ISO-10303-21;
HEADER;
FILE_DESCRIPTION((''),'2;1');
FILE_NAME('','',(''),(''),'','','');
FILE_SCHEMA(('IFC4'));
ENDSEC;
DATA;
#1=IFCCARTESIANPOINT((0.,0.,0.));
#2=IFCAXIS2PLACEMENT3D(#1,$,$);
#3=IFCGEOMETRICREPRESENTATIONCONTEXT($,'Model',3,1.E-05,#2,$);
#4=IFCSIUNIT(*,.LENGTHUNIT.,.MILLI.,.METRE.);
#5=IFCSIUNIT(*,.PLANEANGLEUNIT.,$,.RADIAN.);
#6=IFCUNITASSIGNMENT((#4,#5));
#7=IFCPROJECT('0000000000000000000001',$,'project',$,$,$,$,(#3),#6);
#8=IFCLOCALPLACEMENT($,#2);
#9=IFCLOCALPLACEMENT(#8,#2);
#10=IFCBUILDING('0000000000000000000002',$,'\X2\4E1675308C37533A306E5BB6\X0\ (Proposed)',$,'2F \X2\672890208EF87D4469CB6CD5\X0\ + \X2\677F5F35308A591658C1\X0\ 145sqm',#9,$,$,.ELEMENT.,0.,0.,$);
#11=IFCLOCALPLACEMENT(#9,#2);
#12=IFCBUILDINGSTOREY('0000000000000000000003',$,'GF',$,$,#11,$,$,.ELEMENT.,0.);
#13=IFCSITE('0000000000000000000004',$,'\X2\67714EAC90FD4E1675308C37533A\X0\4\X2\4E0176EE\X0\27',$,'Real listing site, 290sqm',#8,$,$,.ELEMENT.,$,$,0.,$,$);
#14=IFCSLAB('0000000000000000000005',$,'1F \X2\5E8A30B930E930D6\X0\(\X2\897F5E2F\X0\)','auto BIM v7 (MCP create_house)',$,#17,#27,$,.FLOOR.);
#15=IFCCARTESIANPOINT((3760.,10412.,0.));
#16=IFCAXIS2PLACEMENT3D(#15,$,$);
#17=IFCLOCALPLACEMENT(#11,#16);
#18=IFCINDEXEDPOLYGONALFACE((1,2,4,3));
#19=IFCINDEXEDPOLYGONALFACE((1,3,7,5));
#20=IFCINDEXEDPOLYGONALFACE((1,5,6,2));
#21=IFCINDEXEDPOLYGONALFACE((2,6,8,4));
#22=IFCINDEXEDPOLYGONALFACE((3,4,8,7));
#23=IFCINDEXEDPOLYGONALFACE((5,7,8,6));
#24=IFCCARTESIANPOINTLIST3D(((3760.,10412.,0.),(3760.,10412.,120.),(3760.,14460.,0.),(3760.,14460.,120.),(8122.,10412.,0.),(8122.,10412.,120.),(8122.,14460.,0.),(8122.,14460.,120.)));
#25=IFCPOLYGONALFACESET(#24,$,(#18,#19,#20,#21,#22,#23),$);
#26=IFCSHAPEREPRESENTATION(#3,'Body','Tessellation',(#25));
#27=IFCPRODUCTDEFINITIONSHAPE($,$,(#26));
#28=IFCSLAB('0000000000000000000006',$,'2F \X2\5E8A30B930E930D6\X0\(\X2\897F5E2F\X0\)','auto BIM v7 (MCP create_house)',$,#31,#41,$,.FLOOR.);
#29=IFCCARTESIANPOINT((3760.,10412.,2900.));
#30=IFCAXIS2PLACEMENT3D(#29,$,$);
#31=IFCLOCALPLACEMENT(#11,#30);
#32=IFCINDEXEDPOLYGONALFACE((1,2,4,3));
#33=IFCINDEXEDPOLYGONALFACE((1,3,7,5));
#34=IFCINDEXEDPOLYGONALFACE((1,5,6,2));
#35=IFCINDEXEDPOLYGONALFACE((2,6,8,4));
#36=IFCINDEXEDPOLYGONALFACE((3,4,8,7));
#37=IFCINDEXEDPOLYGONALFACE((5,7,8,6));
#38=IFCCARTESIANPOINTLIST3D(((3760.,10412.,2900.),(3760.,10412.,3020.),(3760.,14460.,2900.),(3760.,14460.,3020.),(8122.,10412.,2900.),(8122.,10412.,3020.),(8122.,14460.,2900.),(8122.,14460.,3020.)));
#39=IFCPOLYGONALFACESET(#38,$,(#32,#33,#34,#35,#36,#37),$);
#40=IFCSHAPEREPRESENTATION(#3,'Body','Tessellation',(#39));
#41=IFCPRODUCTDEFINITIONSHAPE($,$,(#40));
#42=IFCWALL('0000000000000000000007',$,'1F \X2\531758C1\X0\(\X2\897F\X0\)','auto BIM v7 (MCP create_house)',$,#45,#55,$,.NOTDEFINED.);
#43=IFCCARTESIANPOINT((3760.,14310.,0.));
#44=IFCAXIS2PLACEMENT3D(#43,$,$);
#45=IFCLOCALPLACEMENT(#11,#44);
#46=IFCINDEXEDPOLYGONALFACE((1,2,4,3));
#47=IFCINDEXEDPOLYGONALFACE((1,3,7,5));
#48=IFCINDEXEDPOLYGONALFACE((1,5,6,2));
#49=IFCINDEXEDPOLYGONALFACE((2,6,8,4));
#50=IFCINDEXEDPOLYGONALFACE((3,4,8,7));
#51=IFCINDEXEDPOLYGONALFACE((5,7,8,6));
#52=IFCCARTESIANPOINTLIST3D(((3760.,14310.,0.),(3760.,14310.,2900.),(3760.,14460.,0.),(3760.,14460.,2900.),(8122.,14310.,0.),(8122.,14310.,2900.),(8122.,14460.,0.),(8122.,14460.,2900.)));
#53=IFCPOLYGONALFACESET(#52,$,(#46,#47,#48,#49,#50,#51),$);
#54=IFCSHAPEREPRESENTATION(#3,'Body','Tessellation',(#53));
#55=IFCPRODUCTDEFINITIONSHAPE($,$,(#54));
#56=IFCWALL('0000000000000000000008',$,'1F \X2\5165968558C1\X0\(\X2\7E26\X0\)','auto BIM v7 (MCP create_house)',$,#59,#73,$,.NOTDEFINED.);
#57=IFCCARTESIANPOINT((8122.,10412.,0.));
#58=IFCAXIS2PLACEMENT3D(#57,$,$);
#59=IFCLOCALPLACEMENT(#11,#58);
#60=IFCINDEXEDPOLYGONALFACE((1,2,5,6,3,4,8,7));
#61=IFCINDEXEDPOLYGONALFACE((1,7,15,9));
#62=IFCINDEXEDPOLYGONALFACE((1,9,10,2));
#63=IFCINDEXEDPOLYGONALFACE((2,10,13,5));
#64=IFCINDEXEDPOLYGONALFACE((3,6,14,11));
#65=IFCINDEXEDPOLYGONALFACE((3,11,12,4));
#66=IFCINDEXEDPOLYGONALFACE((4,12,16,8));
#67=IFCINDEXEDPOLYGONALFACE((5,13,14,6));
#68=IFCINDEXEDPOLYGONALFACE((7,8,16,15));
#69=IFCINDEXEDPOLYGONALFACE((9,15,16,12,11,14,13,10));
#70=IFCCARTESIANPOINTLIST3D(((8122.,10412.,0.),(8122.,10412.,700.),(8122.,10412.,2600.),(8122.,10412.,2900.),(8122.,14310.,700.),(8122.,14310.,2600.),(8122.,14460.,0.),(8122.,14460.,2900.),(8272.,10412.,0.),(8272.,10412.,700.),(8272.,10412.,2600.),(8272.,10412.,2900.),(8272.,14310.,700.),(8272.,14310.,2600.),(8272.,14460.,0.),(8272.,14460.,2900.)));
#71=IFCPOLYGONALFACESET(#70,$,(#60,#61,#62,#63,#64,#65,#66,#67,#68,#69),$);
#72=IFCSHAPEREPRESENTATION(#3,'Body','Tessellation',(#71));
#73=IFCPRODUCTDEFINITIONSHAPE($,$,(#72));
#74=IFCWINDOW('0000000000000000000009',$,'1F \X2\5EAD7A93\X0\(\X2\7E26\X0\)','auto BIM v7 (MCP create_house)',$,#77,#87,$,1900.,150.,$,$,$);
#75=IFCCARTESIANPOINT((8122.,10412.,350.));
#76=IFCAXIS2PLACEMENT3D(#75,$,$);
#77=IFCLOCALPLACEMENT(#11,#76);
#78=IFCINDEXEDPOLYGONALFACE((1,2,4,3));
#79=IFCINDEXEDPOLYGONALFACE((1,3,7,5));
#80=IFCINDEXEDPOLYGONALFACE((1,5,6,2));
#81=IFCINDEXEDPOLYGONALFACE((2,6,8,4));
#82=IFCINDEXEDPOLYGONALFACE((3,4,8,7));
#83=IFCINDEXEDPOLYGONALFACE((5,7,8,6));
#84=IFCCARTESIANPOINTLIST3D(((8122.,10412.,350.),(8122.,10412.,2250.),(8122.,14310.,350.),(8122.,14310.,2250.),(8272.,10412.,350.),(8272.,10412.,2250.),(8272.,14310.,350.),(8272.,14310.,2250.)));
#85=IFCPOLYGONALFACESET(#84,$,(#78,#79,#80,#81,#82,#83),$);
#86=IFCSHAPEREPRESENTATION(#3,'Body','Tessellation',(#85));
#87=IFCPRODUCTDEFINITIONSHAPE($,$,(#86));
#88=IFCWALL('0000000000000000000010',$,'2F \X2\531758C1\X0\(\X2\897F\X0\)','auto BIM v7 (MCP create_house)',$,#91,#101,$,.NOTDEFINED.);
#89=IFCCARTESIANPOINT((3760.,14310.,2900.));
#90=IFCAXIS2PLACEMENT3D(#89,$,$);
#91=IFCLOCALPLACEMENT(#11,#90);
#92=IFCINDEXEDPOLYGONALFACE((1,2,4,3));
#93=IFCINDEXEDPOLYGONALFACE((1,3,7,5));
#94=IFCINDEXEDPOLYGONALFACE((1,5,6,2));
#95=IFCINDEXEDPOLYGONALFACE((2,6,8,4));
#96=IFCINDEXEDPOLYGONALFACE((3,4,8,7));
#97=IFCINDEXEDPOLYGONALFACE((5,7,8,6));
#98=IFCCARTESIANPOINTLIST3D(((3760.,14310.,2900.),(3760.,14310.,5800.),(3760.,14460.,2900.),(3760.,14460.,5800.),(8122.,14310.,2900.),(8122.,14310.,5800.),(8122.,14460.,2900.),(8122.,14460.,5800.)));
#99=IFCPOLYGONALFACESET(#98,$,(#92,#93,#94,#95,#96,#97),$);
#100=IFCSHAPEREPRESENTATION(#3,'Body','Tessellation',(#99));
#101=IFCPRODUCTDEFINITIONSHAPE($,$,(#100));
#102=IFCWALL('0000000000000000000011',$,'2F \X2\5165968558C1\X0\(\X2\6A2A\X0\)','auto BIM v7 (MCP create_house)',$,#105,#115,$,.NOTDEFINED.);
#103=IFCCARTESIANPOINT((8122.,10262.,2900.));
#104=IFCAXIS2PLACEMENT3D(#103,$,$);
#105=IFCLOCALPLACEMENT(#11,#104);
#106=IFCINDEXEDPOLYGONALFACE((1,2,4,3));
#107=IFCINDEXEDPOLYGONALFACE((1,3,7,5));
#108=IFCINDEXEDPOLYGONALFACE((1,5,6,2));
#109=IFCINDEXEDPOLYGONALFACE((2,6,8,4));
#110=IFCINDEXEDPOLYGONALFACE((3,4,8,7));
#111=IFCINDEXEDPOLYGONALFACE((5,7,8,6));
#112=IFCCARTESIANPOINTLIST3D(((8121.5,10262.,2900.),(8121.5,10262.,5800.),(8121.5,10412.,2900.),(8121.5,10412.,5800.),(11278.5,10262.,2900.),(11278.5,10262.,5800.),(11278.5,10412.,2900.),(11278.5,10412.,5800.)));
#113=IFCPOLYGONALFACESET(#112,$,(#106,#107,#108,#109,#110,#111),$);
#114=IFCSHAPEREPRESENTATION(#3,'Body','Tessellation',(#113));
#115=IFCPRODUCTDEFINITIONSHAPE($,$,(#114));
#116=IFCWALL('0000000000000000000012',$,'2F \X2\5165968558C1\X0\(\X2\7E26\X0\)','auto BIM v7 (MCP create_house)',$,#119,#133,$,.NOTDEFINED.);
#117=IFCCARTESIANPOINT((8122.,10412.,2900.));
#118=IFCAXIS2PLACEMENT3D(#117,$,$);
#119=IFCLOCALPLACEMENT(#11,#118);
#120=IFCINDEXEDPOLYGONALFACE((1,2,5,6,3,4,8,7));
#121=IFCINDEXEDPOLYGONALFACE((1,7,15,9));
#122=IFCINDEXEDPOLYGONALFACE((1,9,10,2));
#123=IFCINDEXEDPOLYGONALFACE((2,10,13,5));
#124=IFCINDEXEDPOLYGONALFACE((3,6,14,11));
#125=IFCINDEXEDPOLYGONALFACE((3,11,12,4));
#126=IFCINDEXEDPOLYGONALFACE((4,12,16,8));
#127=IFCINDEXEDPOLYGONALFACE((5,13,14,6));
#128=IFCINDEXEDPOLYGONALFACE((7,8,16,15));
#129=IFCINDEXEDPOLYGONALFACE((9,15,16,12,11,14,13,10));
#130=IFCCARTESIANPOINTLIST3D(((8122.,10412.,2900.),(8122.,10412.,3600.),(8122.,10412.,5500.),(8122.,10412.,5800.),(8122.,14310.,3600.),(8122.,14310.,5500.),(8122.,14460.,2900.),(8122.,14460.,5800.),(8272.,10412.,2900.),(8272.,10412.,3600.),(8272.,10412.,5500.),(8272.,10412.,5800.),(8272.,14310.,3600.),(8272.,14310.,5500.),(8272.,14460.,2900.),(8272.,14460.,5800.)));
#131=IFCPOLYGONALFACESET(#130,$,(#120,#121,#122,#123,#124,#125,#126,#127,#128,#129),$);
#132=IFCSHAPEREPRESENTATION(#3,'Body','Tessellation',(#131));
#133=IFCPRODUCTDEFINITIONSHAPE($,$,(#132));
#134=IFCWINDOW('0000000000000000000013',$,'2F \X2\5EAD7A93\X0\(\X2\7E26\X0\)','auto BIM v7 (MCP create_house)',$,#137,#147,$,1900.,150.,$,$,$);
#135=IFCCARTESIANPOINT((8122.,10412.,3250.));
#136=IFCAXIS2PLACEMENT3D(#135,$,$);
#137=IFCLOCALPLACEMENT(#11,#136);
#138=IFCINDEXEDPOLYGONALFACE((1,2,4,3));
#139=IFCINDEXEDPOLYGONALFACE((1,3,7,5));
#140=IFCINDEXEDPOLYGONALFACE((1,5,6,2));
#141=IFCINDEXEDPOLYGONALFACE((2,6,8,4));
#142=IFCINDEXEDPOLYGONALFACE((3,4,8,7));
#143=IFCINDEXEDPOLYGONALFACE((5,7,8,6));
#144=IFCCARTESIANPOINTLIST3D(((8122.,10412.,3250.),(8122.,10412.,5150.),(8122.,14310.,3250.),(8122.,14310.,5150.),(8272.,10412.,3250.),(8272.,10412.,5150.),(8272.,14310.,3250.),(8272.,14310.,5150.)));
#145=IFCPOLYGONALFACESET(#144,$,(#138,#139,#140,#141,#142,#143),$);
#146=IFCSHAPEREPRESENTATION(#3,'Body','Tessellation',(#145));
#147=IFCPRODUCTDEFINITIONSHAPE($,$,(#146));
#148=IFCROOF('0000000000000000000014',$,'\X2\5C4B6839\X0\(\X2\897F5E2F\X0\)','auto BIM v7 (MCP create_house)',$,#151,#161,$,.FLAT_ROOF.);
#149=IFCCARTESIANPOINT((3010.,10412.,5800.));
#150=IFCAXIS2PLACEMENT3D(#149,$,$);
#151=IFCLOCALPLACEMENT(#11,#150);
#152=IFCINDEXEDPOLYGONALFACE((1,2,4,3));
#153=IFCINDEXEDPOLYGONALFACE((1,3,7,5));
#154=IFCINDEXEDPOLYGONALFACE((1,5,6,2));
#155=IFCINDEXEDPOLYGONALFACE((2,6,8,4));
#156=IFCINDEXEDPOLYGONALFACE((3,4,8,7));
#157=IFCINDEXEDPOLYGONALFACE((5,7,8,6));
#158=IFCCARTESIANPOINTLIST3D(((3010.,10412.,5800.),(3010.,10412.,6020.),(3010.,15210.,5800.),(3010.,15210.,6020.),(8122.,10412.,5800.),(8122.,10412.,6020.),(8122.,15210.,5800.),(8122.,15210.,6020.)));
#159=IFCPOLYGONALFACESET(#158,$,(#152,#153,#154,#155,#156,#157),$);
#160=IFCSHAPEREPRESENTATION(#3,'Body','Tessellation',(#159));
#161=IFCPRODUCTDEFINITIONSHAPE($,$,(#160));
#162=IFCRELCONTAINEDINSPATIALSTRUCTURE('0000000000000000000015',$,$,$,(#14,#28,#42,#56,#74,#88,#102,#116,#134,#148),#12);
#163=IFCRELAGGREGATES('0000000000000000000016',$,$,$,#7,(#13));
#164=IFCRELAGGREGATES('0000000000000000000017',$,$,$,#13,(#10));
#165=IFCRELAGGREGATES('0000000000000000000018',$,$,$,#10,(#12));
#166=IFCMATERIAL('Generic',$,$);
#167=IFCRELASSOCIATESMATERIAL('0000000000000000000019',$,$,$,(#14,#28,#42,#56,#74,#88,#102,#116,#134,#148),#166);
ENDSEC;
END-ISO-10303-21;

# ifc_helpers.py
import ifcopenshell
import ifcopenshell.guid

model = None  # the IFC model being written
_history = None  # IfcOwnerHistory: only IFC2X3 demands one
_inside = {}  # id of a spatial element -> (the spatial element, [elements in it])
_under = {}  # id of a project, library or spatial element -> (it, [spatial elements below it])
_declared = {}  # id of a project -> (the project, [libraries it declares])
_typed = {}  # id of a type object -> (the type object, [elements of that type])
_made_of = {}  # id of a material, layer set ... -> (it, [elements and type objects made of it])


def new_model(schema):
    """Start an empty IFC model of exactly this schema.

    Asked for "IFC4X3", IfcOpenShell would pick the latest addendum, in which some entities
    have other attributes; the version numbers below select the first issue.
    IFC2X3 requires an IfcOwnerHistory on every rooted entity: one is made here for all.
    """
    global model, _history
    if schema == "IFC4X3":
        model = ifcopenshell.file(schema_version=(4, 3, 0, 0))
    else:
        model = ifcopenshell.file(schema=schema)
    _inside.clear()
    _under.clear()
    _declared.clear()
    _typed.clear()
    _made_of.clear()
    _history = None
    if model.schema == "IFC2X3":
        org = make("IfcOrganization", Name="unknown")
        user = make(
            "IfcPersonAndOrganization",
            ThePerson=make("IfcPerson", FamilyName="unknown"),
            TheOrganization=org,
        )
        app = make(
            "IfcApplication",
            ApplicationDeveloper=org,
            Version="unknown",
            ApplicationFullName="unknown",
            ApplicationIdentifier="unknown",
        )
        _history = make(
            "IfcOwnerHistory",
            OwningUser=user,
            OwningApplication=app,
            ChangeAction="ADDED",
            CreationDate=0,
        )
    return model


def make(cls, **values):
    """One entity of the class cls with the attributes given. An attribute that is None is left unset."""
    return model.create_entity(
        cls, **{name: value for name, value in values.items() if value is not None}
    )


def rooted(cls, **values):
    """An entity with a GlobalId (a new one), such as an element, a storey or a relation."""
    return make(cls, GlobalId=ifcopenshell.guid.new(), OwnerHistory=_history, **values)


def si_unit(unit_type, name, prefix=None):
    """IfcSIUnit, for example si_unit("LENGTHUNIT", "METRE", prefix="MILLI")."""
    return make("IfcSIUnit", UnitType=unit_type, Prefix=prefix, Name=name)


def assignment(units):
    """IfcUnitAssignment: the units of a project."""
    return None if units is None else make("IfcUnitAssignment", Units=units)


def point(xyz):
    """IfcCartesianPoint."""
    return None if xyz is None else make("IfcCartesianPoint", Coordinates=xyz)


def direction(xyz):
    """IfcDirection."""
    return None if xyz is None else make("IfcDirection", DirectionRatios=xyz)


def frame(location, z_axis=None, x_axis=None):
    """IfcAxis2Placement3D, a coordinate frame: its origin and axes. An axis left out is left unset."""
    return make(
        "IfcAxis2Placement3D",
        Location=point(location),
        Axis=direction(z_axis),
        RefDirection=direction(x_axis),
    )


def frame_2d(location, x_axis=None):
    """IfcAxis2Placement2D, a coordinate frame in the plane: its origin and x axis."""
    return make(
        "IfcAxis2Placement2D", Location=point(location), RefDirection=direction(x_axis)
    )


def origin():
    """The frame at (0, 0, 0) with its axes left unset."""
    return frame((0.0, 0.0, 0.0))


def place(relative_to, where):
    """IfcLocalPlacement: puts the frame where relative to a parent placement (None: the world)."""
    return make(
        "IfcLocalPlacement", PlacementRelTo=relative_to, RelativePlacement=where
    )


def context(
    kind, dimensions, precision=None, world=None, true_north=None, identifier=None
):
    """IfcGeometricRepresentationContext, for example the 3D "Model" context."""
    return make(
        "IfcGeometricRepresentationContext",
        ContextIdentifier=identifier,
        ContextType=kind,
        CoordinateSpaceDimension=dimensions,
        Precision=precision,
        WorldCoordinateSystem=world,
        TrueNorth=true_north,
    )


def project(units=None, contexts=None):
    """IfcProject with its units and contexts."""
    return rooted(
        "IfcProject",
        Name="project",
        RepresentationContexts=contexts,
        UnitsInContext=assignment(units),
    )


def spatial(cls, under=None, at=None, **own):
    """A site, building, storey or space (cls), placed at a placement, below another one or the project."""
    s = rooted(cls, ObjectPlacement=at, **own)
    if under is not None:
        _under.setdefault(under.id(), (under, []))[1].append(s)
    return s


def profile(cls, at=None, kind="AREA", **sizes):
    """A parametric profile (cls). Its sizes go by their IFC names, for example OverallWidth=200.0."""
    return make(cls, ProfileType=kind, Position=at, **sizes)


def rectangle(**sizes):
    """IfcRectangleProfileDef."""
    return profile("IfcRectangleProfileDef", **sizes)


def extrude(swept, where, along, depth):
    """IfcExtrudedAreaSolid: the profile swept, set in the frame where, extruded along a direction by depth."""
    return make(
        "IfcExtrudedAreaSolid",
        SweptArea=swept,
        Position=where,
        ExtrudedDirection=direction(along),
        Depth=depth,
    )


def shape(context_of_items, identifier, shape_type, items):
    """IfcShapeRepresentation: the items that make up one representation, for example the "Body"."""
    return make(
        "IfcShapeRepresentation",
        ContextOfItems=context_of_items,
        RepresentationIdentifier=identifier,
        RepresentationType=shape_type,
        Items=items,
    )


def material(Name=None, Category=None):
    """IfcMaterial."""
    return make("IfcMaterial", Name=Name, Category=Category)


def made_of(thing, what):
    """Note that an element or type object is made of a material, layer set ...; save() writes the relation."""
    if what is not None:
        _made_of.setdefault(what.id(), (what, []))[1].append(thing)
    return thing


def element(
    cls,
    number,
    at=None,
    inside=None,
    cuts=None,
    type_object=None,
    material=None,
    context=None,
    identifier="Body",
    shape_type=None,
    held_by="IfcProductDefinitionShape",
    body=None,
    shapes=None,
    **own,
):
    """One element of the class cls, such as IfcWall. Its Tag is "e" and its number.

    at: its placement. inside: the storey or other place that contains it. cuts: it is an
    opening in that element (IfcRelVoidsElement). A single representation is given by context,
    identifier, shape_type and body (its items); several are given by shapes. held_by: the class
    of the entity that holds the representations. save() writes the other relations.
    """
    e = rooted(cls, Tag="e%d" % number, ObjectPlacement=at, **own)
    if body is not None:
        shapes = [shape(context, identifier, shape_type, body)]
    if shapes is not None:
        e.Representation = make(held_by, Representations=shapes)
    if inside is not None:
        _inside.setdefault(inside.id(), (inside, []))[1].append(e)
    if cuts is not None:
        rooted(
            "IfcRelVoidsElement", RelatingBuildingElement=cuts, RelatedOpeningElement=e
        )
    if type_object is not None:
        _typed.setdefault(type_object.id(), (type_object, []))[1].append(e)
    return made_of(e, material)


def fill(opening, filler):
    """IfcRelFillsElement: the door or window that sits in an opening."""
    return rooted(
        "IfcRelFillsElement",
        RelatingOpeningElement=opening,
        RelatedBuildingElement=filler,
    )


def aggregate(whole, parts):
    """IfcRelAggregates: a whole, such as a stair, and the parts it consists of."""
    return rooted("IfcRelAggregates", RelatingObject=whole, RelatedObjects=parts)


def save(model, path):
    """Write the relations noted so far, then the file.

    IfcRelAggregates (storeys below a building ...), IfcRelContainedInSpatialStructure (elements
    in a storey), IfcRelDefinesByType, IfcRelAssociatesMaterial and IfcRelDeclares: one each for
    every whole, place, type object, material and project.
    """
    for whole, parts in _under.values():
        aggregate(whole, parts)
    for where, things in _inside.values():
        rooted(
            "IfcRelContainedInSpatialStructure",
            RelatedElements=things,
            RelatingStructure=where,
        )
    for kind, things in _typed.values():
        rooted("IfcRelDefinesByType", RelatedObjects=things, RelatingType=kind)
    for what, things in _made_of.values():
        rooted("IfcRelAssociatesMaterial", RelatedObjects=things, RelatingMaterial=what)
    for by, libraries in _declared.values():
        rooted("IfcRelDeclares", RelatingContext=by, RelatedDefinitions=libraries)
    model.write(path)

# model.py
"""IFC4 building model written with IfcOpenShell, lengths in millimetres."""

from ifc_helpers import new_model, si_unit, frame, frame_2d, origin, place, context, project, spatial, rectangle, extrude, material, element, fill, save


model = new_model("IFC4")

# Units and contexts
model_context = context("Model", 3, precision=1e-05, world=origin())
ifc_project = project(units=[si_unit("LENGTHUNIT", "METRE", prefix="MILLI"), si_unit("PLANEANGLEUNIT", "RADIAN")], contexts=[model_context])

# Site, building, storey
site_placement = place(None, origin())
site = spatial("IfcSite", under=ifc_project, at=site_placement, Name="東京都世田谷区4丁目27", ObjectType="Real listing site, 290sqm", CompositionType="ELEMENT", RefElevation=0.0)
building_placement = place(site_placement, origin())
building = spatial("IfcBuilding", under=site, at=building_placement, Name="世田谷区の家 (Proposed)", ObjectType="2F 木造軸組構法 + 板張り外壁 145sqm", CompositionType="ELEMENT", ElevationOfRefHeight=0.0, ElevationOfTerrain=0.0)
storey_placement = place(building_placement, origin())
storey = spatial("IfcBuildingStorey", under=building, at=storey_placement, Name="GF", CompositionType="ELEMENT", Elevation=0.0)

# Slabs
ifc_material = material(Name="Generic")
slab_1_placement = place(storey_placement, frame((3760.0, 10412.0, 0.0)))
element("IfcSlab", 1, at=slab_1_placement, inside=storey, material=ifc_material, Name="1F 床スラブ(西帯)", Description="auto BIM v7 (MCP create_house)", PredefinedType="FLOOR", context=model_context, shape_type="SweptSolid", body=[
    extrude(rectangle(XDim=4362.0, YDim=4048.0, at=frame_2d((2181.0, 2024.0))), frame((3760.0, 10412.0, 0.0)), (0.0, 0.0, 1.0), 120.0),
])
slab_2_placement = place(storey_placement, frame((3760.0, 10412.0, 2900.0)))
element("IfcSlab", 2, at=slab_2_placement, inside=storey, material=ifc_material, Name="2F 床スラブ(西帯)", Description="auto BIM v7 (MCP create_house)", PredefinedType="FLOOR", context=model_context, shape_type="SweptSolid", body=[
    extrude(rectangle(XDim=4362.0, YDim=4048.0, at=frame_2d((2181.0, 2024.0))), frame((3760.0, 10412.0, 2900.0)), (0.0, 0.0, 1.0), 120.0),
])

# Wall
wall_1_placement = place(storey_placement, frame((3760.0, 14310.0, 0.0)))
element("IfcWall", 3, at=wall_1_placement, inside=storey, material=ifc_material, Name="1F 北壁(西)", Description="auto BIM v7 (MCP create_house)", PredefinedType="NOTDEFINED", context=model_context, shape_type="SweptSolid", body=[
    extrude(rectangle(XDim=4362.0, YDim=150.0, at=frame_2d((2181.0, 75.0))), frame((3760.0, 14310.0, 0.0)), (0.0, 0.0, 1.0), 2900.0),
])

# Wall, opening, window
wall_2_placement = place(storey_placement, frame((8122.0, 10412.0, 0.0)))
wall_2 = element("IfcWall", 4, at=wall_2_placement, inside=storey, material=ifc_material, Name="1F 入隅壁(縦)", Description="auto BIM v7 (MCP create_house)", PredefinedType="NOTDEFINED", context=model_context, shape_type="SweptSolid", body=[
    extrude(rectangle(XDim=150.0, YDim=4048.0, at=frame_2d((75.0, 2024.0))), frame((8122.0, 10412.0, 0.0)), (0.0, 0.0, 1.0), 2900.0),
])
opening_1_placement = place(storey_placement, frame((8122.0, 10412.0, 350.0)))
opening_1 = element("IfcOpeningElement", 5, at=opening_1_placement, cuts=wall_2, PredefinedType="NOTDEFINED", context=model_context, shape_type="SweptSolid", body=[
    extrude(rectangle(XDim=150.0, YDim=3898.0, at=frame_2d((75.0, 1949.0))), frame((8122.0, 10412.0, 350.0)), (0.0, 0.0, 1.0), 1900.0),
])
window_1_placement = place(storey_placement, frame((8122.0, 10412.0, 350.0)))
window_1 = element("IfcWindow", 6, at=window_1_placement, inside=storey, material=ifc_material, Name="1F 庭窓(縦)", Description="auto BIM v7 (MCP create_house)", OverallHeight=1900.0, OverallWidth=150.0, context=model_context, shape_type="SweptSolid", body=[
    extrude(rectangle(XDim=150.0, YDim=3898.0, at=frame_2d((75.0, 1949.0))), frame((8122.0, 10412.0, 350.0)), (0.0, 0.0, 1.0), 1900.0),
])
fill(opening_1, window_1)

# Walls
wall_3_placement = place(storey_placement, frame((3760.0, 14310.0, 2900.0)))
element("IfcWall", 7, at=wall_3_placement, inside=storey, material=ifc_material, Name="2F 北壁(西)", Description="auto BIM v7 (MCP create_house)", PredefinedType="NOTDEFINED", context=model_context, shape_type="SweptSolid", body=[
    extrude(rectangle(XDim=4362.0, YDim=150.0, at=frame_2d((2181.0, 75.0))), frame((3760.0, 14310.0, 2900.0)), (0.0, 0.0, 1.0), 2900.0),
])
wall_4_placement = place(storey_placement, frame((8122.0, 10262.0, 2900.0)))
element("IfcWall", 8, at=wall_4_placement, inside=storey, material=ifc_material, Name="2F 入隅壁(横)", Description="auto BIM v7 (MCP create_house)", PredefinedType="NOTDEFINED", context=model_context, shape_type="SweptSolid", body=[
    extrude(rectangle(XDim=3157.0, YDim=150.0, at=frame_2d((1578.0, 75.0))), frame((8122.0, 10262.0, 2900.0)), (0.0, 0.0, 1.0), 2900.0),
])

# Wall, opening, window
wall_5_placement = place(storey_placement, frame((8122.0, 10412.0, 2900.0)))
wall_5 = element("IfcWall", 9, at=wall_5_placement, inside=storey, material=ifc_material, Name="2F 入隅壁(縦)", Description="auto BIM v7 (MCP create_house)", PredefinedType="NOTDEFINED", context=model_context, shape_type="SweptSolid", body=[
    extrude(rectangle(XDim=150.0, YDim=4048.0, at=frame_2d((75.0, 2024.0))), frame((8122.0, 10412.0, 2900.0)), (0.0, 0.0, 1.0), 2900.0),
])
opening_2_placement = place(storey_placement, frame((8122.0, 10412.0, 3250.0)))
opening_2 = element("IfcOpeningElement", 10, at=opening_2_placement, cuts=wall_5, PredefinedType="NOTDEFINED", context=model_context, shape_type="SweptSolid", body=[
    extrude(rectangle(XDim=150.0, YDim=3898.0, at=frame_2d((75.0, 1949.0))), frame((8122.0, 10412.0, 3250.0)), (0.0, 0.0, 1.0), 1900.0),
])
window_2_placement = place(storey_placement, frame((8122.0, 10412.0, 3250.0)))
window_2 = element("IfcWindow", 11, at=window_2_placement, inside=storey, material=ifc_material, Name="2F 庭窓(縦)", Description="auto BIM v7 (MCP create_house)", OverallHeight=1900.0, OverallWidth=150.0, context=model_context, shape_type="SweptSolid", body=[
    extrude(rectangle(XDim=150.0, YDim=3898.0, at=frame_2d((75.0, 1949.0))), frame((8122.0, 10412.0, 3250.0)), (0.0, 0.0, 1.0), 1900.0),
])
fill(opening_2, window_2)

# Roof
for number, where, name in (
    (12, (3010.0, 10412.0, 5800.0), "屋根(西帯)"),
):
    element("IfcRoof", number, at=place(storey_placement, frame(where)), inside=storey, material=ifc_material, Name=name, Description="auto BIM v7 (MCP create_house)", PredefinedType="FLAT_ROOF", context=model_context, shape_type="SweptSolid", body=[
        extrude(rectangle(XDim=5112.0, YDim=4798.0, at=frame_2d((2556.0, 2399.0))), frame((3010.0, 10412.0, 5800.0)), (0.0, 0.0, 1.0), 220.0),
    ])

save(model, "model.ifc")
